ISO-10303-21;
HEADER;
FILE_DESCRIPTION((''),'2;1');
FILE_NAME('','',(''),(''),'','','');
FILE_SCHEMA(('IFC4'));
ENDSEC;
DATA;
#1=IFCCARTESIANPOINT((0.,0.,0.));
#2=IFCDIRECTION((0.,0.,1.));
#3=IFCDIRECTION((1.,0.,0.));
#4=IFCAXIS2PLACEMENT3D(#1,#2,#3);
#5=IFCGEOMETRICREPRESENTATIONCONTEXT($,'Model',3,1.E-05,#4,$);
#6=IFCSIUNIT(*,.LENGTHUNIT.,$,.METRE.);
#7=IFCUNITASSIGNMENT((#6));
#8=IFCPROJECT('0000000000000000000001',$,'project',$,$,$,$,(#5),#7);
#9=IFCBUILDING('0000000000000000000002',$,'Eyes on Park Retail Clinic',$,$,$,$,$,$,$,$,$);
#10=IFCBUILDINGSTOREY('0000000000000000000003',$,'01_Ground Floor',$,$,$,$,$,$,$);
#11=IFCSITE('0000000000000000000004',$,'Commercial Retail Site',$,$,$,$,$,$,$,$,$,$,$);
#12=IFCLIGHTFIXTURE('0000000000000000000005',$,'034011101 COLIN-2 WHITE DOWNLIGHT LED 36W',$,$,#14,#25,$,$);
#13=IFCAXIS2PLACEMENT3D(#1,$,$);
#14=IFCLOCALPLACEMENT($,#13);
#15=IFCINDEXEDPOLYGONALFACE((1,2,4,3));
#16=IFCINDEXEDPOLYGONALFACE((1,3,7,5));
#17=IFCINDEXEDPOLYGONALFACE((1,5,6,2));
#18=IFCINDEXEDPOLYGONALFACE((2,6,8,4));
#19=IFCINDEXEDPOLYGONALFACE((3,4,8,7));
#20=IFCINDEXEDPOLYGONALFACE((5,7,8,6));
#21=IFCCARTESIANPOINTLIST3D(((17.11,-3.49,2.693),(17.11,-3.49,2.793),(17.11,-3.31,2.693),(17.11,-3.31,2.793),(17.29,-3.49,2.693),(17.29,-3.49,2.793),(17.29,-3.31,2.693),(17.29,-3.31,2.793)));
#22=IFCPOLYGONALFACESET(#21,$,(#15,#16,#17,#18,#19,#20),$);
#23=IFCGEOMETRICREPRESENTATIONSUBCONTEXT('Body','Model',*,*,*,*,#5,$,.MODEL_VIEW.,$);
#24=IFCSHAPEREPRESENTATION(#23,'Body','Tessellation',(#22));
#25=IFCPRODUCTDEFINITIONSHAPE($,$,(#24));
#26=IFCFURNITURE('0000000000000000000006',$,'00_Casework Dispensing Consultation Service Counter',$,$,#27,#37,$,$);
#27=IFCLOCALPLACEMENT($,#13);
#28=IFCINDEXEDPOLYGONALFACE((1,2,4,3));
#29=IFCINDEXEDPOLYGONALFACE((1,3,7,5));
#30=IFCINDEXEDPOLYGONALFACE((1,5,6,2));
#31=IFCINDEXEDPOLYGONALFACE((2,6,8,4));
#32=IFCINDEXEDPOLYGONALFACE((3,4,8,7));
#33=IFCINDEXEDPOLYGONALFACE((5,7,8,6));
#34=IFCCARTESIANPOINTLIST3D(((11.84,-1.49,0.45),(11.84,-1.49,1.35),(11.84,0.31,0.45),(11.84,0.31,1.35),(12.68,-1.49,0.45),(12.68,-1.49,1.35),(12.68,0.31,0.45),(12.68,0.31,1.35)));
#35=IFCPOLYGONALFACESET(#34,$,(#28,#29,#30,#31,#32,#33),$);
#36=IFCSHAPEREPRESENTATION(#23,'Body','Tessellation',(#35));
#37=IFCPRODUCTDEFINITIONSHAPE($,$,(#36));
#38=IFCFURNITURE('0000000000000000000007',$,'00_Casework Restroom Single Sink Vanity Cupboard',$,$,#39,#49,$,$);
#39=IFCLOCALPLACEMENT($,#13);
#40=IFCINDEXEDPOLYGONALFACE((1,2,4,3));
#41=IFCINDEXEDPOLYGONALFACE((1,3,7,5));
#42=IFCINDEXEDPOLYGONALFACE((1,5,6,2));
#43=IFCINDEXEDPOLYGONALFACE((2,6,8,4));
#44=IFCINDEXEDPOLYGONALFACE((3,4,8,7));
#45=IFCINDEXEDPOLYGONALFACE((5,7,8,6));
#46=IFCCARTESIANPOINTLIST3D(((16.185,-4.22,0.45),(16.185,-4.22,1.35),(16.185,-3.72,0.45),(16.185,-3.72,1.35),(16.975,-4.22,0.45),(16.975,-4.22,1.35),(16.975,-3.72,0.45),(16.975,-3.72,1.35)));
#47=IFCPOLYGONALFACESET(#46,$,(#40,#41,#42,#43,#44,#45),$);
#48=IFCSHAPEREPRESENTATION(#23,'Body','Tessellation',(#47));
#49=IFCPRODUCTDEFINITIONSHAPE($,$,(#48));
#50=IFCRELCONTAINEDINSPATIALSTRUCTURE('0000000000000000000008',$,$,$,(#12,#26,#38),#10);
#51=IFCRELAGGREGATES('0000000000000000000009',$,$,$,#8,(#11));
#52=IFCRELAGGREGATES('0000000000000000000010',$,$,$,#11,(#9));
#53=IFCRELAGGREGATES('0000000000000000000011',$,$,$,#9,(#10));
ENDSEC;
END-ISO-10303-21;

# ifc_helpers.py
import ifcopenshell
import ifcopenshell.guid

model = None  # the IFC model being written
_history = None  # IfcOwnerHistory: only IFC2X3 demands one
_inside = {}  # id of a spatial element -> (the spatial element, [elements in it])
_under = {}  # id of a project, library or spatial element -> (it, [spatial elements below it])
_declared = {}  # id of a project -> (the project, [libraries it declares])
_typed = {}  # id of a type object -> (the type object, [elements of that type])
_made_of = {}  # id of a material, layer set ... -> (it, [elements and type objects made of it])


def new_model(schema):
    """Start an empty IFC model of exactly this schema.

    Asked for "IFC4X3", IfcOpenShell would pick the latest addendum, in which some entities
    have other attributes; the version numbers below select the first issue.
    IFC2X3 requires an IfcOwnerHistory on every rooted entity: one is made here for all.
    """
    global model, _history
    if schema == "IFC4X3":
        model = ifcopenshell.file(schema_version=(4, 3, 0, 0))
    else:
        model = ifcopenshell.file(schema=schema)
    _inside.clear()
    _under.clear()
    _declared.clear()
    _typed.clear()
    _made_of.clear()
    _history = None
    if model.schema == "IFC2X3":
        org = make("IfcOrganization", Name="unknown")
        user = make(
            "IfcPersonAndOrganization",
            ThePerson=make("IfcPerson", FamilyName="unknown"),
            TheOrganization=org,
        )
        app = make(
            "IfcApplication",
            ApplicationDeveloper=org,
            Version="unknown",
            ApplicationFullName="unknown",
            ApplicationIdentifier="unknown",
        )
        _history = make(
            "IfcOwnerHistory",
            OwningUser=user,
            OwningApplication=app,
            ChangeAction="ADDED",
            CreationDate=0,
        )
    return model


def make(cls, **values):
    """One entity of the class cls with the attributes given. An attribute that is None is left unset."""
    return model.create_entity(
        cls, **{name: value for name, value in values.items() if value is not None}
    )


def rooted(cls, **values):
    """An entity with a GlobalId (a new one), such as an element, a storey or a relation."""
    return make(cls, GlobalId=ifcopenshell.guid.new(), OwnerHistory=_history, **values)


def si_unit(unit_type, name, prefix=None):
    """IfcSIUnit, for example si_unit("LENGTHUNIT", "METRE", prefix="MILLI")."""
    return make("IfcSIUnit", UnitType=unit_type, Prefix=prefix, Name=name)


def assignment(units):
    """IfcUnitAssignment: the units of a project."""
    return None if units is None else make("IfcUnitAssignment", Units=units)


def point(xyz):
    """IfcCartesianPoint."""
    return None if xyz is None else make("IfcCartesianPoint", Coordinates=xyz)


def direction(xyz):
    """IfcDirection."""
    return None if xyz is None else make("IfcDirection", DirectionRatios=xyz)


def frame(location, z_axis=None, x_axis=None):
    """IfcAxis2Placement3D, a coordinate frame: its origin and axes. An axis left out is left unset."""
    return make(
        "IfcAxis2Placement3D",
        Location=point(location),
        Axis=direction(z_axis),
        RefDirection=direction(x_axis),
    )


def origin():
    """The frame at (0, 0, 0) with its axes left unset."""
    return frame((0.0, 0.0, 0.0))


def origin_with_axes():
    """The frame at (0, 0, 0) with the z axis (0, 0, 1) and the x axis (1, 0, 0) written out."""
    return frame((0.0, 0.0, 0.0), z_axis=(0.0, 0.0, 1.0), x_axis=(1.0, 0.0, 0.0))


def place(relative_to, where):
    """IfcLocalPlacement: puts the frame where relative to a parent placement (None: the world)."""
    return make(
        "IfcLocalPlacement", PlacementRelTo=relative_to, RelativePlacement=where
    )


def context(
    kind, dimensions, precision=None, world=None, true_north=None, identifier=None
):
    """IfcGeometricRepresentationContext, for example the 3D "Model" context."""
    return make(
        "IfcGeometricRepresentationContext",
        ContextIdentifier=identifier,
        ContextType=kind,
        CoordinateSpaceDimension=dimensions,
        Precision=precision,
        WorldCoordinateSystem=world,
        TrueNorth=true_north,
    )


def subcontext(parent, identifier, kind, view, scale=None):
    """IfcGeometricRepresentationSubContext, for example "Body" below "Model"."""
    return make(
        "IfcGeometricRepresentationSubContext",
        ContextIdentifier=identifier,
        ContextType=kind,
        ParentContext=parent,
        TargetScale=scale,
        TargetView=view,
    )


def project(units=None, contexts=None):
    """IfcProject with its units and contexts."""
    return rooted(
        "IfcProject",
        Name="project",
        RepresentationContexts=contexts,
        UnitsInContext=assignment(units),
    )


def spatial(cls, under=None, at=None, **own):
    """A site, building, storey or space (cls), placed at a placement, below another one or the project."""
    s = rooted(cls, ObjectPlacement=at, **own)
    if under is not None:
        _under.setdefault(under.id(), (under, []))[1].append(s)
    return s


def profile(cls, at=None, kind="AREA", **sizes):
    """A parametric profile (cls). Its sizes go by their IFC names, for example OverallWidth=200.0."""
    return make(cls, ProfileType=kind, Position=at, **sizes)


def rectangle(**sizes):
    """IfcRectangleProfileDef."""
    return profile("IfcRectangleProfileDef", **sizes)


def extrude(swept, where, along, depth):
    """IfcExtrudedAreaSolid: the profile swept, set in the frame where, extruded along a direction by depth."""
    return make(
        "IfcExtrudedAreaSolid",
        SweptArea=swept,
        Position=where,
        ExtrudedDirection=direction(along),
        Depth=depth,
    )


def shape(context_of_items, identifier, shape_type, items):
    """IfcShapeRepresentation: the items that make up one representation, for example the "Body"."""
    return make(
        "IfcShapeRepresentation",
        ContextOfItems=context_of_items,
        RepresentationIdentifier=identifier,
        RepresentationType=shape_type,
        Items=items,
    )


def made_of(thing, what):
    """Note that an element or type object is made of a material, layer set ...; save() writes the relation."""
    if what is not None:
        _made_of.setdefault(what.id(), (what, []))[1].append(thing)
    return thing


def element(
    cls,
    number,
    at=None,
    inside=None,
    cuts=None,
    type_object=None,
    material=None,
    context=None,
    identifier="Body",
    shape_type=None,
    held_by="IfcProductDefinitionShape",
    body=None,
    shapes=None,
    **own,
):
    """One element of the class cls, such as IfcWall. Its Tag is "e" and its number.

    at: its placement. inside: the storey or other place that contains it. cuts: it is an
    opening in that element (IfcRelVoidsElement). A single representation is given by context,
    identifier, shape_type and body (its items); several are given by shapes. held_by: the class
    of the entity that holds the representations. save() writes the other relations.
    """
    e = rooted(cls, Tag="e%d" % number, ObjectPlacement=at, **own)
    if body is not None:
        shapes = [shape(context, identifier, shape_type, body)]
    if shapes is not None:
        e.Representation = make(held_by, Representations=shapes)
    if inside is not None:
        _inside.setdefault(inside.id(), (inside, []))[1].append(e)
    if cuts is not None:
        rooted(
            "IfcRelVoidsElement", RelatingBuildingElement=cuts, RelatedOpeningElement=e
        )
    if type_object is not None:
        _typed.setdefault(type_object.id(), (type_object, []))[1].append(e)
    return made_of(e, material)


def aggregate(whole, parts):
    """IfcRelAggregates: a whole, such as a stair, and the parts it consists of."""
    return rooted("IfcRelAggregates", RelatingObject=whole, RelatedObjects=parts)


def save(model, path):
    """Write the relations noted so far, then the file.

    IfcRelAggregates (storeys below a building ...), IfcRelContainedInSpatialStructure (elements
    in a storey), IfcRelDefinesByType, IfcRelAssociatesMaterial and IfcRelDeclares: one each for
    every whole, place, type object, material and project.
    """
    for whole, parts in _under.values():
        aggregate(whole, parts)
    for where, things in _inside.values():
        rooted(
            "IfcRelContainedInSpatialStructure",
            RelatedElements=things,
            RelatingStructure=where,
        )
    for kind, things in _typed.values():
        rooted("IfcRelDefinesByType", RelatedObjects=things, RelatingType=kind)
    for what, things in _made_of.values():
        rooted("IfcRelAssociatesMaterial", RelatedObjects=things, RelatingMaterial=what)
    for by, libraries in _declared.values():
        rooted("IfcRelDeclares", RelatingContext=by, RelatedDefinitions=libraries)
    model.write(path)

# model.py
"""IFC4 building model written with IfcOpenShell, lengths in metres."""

from ifc_helpers import new_model, si_unit, frame, origin, origin_with_axes, place, context, subcontext, project, spatial, rectangle, extrude, element, save


model = new_model("IFC4")

# Units and contexts
model_context = context("Model", 3, precision=1e-05, world=origin_with_axes())
body_context = subcontext(model_context, "Body", "Model", "MODEL_VIEW")
ifc_project = project(units=[si_unit("LENGTHUNIT", "METRE")], contexts=[model_context])

# Site, building, storey
site = spatial("IfcSite", under=ifc_project, Name="Commercial Retail Site")
building = spatial("IfcBuilding", under=site, Name="Eyes on Park Retail Clinic")
storey = spatial("IfcBuildingStorey", under=building, Name="01_Ground Floor")

# Light fixture
for number, where, z_axis, x_axis, name in (
    (1, (17.2, -3.4, 2.693), (0.0, 0.0, 1.0), (1.0, 0.0, 0.0), "034011101 COLIN-2 WHITE DOWNLIGHT LED 36W"),
):
    element("IfcLightFixture", number, at=place(None, frame(where, z_axis=z_axis, x_axis=x_axis)), inside=storey, Name=name, context=body_context, shape_type="SweptSolid", body=[
        extrude(rectangle(XDim=0.18, YDim=0.18), origin(), (0.0, 0.0, 1.0), 0.1),
    ])

# Furniture
furniture_1_placement = place(None, frame((12.26, -0.59, 0.45), z_axis=(0.0, 0.0, 1.0), x_axis=(1.0, 0.0, 0.0)))
element("IfcFurniture", 2, at=furniture_1_placement, inside=storey, Name="00_Casework Dispensing Consultation Service Counter", context=body_context, shape_type="SweptSolid", body=[
    extrude(rectangle(XDim=0.84, YDim=1.8), origin(), (0.0, 0.0, 1.0), 0.9),
])
furniture_2_placement = place(None, frame((16.58, -3.97, 0.45), z_axis=(0.0, 0.0, 1.0), x_axis=(1.0, 0.0, 0.0)))
element("IfcFurniture", 3, at=furniture_2_placement, inside=storey, Name="00_Casework Restroom Single Sink Vanity Cupboard", context=body_context, shape_type="SweptSolid", body=[
    extrude(rectangle(XDim=0.79, YDim=0.5), origin(), (0.0, 0.0, 1.0), 0.9),
])

save(model, "model.ifc")
